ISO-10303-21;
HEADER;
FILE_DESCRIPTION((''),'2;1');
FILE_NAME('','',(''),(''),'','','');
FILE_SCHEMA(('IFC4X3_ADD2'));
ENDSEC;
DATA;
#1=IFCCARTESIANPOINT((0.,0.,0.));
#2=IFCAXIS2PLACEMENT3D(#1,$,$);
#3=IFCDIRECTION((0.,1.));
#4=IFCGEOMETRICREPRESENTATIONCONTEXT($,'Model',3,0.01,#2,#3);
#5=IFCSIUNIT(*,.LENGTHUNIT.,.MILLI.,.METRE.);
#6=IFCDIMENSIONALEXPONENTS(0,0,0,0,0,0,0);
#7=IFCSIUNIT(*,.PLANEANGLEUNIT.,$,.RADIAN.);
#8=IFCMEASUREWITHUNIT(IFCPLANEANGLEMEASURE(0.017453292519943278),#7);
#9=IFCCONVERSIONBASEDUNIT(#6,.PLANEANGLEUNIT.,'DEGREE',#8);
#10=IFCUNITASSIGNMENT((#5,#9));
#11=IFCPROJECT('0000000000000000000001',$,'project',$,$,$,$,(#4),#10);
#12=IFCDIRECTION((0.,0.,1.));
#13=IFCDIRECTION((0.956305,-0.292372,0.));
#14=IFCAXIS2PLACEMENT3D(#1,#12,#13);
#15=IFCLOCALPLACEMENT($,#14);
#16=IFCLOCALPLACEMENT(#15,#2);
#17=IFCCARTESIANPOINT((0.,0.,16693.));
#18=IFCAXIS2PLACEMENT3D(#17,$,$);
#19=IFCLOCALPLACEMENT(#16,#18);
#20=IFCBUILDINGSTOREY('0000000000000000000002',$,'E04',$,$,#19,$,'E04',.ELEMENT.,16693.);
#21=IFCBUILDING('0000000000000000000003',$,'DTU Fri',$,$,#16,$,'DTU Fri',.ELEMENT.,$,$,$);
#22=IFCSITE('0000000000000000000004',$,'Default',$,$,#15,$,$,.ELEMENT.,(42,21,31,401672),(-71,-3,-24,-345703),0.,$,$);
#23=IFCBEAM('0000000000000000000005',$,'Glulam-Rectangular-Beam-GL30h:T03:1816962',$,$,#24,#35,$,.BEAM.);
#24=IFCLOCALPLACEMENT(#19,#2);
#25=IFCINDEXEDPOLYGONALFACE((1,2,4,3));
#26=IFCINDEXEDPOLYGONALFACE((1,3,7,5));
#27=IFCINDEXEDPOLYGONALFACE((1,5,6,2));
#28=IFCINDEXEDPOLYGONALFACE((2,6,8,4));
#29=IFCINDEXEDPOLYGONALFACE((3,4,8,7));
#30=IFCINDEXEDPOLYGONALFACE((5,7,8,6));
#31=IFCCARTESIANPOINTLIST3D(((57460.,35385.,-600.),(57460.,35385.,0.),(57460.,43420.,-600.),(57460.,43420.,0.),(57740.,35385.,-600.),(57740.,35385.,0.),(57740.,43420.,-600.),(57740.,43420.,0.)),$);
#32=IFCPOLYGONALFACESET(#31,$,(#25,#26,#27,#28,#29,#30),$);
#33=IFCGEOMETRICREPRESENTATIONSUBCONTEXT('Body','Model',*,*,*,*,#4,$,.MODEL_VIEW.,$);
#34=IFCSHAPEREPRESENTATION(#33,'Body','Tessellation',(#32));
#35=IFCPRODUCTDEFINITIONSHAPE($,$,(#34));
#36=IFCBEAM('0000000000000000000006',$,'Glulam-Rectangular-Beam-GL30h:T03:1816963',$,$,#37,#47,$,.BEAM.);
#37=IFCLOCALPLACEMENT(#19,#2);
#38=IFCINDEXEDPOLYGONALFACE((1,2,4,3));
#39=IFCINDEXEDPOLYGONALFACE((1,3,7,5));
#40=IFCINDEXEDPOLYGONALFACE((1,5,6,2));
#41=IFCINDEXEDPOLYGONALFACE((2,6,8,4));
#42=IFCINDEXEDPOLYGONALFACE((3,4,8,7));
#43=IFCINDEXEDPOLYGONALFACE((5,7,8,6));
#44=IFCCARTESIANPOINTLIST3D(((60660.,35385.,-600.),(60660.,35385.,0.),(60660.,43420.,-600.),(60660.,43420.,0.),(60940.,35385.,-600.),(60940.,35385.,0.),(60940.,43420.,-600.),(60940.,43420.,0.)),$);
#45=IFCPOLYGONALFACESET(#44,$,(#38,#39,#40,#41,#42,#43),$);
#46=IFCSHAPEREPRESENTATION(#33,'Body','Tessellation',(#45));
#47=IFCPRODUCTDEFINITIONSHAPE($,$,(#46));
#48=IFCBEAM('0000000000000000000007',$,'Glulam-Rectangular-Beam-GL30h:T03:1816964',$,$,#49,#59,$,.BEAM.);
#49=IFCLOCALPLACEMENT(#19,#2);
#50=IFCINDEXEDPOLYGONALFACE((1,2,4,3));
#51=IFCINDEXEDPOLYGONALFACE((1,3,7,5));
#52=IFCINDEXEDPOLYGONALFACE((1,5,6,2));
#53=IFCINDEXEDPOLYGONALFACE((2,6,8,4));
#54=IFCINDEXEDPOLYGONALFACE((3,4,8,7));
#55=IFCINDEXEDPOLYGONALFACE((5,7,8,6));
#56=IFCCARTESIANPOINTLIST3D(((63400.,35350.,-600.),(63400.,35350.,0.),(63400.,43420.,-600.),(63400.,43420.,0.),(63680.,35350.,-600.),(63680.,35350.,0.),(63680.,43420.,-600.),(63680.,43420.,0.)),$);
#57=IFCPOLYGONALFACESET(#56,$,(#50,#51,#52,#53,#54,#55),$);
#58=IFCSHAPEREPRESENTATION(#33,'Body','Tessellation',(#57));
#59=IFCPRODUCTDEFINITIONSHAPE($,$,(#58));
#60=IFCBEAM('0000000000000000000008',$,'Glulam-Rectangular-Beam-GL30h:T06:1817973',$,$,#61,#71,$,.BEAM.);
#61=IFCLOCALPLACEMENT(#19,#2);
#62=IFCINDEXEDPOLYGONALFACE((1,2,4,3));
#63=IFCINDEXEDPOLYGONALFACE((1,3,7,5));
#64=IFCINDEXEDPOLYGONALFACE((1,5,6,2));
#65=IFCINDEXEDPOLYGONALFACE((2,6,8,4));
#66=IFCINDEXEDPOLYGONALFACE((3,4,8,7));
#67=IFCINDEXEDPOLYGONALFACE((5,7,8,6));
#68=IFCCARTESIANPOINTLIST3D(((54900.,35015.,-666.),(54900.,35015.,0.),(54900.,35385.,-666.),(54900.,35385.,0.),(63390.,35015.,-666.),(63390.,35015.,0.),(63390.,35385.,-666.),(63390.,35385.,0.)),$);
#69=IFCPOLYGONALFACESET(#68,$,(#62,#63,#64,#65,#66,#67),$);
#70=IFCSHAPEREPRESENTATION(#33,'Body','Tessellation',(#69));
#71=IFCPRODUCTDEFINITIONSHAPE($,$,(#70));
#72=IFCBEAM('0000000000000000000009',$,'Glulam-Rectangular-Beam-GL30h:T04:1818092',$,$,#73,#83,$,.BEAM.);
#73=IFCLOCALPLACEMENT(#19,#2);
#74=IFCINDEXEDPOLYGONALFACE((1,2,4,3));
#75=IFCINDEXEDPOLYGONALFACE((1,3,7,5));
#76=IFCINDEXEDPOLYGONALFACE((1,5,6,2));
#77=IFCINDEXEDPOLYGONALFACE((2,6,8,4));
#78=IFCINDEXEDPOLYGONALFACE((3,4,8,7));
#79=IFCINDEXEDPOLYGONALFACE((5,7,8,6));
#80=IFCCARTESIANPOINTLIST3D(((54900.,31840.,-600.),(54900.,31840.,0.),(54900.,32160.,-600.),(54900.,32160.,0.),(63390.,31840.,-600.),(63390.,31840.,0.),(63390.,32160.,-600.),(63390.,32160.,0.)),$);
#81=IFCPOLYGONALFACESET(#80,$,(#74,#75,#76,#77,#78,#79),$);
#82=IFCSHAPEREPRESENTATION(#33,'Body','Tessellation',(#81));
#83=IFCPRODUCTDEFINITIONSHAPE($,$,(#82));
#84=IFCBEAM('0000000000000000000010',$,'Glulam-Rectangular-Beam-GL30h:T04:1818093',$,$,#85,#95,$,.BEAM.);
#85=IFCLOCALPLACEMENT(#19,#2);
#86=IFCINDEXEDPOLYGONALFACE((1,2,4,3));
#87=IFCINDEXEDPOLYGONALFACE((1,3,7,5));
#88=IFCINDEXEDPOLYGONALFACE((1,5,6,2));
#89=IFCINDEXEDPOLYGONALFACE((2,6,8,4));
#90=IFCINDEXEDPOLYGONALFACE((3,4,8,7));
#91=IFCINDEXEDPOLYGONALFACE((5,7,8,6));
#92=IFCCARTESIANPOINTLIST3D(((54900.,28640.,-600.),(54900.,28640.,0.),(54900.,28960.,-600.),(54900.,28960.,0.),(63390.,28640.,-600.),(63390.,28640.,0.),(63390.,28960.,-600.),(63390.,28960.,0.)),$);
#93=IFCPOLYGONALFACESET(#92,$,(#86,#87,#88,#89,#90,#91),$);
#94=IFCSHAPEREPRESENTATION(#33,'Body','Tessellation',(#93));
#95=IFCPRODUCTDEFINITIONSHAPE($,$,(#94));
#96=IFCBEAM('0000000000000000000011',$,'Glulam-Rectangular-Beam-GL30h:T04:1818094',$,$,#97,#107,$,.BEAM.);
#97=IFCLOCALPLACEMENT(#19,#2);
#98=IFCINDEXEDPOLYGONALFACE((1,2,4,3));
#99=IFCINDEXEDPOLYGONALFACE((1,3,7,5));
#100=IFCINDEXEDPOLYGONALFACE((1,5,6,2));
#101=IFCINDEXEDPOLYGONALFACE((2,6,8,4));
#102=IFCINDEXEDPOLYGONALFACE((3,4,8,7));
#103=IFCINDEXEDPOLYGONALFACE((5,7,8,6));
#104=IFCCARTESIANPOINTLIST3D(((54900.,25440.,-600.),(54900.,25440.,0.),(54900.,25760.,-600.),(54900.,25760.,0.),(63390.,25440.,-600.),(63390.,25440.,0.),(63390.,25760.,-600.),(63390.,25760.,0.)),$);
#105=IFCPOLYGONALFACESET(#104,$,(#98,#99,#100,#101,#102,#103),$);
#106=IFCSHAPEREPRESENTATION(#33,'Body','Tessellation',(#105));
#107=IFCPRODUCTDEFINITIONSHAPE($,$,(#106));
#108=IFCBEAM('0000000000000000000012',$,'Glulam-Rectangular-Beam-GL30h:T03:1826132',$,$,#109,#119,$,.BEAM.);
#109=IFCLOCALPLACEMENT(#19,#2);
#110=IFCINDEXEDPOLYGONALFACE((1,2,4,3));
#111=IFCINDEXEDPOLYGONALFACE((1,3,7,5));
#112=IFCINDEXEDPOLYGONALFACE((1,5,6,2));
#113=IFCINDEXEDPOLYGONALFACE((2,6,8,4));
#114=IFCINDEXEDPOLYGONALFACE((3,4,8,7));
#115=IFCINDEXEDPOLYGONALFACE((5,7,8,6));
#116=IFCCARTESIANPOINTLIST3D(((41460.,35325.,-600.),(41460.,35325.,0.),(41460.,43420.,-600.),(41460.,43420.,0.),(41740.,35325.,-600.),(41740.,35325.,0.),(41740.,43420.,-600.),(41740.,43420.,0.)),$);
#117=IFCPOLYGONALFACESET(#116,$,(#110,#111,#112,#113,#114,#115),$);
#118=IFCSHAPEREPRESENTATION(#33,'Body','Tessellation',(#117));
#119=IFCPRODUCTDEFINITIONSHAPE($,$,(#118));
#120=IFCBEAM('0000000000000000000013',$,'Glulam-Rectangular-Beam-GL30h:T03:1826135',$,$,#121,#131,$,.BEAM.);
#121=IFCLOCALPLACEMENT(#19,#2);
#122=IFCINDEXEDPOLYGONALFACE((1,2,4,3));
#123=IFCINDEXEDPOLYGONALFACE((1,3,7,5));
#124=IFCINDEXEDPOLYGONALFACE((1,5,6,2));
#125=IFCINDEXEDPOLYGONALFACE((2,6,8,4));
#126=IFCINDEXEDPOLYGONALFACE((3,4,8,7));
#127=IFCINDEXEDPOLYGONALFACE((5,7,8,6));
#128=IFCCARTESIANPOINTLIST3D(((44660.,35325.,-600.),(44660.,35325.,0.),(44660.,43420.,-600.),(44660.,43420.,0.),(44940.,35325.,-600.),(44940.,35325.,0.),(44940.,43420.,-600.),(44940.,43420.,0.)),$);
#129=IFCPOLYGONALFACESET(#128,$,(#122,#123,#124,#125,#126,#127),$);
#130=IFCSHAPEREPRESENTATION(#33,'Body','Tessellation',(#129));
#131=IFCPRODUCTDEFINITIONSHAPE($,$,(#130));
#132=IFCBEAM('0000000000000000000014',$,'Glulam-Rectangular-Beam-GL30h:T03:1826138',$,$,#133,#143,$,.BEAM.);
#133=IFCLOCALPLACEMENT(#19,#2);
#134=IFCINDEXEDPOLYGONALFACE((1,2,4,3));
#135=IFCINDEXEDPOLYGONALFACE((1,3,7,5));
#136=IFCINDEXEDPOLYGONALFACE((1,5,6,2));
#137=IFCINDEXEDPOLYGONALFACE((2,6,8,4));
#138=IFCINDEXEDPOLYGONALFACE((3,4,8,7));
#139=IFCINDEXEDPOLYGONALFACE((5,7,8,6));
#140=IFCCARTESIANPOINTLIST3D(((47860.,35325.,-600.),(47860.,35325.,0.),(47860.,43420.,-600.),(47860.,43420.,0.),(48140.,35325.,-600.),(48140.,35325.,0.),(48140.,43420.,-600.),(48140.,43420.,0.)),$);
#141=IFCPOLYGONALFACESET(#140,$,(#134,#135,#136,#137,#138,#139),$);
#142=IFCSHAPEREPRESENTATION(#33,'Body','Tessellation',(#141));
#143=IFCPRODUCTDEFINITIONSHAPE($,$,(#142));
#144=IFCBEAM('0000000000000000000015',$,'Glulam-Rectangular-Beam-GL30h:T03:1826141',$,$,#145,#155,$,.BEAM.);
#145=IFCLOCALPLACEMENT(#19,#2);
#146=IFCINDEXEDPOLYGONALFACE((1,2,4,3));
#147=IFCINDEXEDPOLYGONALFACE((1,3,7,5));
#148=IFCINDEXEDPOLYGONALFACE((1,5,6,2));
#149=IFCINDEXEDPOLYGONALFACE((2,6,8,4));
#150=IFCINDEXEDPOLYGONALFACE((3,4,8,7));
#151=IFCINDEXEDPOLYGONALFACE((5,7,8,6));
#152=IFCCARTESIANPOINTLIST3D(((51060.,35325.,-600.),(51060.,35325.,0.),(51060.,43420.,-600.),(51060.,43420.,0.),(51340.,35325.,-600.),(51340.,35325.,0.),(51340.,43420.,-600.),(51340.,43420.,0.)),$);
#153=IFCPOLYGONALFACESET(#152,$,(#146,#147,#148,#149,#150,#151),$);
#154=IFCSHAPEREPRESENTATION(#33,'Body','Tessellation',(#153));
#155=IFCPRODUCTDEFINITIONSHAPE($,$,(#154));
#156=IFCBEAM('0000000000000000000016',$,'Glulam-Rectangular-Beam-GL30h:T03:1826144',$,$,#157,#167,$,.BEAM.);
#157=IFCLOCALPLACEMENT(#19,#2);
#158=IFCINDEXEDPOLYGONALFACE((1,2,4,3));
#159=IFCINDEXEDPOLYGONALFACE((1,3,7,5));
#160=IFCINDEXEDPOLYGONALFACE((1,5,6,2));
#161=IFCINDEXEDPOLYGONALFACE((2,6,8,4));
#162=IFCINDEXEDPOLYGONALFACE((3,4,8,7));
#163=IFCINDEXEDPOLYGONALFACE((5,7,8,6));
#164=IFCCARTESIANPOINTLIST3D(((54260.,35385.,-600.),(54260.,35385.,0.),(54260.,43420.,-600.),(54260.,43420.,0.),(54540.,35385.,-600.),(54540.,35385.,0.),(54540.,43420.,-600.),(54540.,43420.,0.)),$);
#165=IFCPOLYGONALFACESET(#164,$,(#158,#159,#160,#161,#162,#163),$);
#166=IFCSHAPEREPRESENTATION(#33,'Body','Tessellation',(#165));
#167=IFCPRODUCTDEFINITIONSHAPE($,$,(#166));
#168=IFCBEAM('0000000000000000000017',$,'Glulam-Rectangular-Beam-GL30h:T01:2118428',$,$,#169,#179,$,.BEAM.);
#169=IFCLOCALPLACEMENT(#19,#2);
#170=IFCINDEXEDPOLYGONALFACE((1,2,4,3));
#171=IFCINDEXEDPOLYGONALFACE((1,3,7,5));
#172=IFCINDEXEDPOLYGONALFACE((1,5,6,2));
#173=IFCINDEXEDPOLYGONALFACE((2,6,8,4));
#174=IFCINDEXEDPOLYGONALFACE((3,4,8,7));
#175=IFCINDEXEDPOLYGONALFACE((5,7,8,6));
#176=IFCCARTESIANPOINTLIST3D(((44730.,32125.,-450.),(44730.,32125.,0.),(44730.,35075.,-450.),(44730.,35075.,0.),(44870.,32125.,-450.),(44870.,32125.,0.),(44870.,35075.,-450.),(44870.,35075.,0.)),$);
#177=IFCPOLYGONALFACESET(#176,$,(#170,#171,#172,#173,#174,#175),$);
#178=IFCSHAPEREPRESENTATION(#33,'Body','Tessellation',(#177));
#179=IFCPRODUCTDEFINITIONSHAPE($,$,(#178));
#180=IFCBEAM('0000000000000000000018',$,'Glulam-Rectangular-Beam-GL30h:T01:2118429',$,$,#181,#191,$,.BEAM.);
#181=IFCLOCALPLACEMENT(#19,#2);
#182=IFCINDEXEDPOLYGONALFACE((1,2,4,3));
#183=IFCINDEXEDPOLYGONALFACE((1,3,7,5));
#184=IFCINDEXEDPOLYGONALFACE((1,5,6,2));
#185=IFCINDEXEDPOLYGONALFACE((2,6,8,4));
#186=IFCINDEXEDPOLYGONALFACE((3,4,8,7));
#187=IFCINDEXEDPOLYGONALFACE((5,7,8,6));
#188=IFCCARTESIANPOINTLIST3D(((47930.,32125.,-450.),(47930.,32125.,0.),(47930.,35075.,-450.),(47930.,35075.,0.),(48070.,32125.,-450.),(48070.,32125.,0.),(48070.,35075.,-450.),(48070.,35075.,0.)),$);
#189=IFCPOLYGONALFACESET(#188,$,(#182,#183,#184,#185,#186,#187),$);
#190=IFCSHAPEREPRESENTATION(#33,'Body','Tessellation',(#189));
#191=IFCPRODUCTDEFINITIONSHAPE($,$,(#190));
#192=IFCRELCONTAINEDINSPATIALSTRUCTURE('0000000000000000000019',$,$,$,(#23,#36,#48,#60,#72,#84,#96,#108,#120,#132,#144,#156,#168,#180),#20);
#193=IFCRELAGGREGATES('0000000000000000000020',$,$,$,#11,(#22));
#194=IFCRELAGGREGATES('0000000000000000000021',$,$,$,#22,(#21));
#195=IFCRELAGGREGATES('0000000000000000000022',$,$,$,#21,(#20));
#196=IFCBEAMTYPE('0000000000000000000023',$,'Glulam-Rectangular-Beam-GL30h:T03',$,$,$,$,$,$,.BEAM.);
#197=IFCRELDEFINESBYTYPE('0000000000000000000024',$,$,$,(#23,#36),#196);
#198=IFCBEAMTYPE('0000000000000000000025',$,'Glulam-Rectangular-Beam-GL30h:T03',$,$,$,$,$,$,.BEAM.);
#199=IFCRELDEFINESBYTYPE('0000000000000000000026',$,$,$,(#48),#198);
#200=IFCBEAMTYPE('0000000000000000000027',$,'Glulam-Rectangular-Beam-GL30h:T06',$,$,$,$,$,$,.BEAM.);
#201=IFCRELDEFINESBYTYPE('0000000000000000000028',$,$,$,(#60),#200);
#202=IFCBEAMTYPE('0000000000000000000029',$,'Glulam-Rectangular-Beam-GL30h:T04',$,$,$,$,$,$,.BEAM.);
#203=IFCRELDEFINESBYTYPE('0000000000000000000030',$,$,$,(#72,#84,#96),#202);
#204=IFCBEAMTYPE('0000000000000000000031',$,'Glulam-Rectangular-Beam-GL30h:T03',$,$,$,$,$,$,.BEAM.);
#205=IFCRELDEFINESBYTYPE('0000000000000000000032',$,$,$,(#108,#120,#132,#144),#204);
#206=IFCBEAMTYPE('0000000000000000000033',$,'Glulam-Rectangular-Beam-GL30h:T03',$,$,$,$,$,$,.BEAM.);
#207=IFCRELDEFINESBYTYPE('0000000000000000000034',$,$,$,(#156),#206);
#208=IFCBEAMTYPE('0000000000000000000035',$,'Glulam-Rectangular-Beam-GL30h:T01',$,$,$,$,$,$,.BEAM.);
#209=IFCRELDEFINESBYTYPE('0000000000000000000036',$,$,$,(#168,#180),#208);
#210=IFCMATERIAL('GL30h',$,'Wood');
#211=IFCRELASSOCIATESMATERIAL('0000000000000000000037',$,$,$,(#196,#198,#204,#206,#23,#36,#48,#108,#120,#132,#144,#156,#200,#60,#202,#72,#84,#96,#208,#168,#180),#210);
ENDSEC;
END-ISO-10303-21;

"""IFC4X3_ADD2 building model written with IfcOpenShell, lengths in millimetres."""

from ifc_helpers import new_model, entity, si_unit, converted_unit, direction, frame, origin, origin_2d_with_axis, place, context, subcontext, project, spatial, rectangle, extrude, source, transform, mapped, material, material_profile, profile_set, profile_usage, type_object, type_shapes, element, save


model = new_model("IFC4X3_ADD2")

# Units and contexts
model_context = context("Model", 3, precision=0.01, world=origin(), true_north=direction((0.0, 1.0)))
body_context = subcontext(model_context, "Body", "Model", "MODEL_VIEW")
ifc_project = project(units=[si_unit("LENGTHUNIT", "METRE", prefix="MILLI"), converted_unit("PLANEANGLEUNIT", "DEGREE", entity("IfcPlaneAngleMeasure", 0.017453292519943278), si_unit("PLANEANGLEUNIT", "RADIAN"), dimensions=[0, 0, 0, 0, 0, 0, 0])], contexts=[model_context])

# Site, building, storey
site_placement = place(None, frame((0.0, 0.0, 0.0), z_axis=(0.0, 0.0, 1.0), x_axis=(0.956305, -0.292372, 0.0)))
site = spatial("IfcSite", under=ifc_project, at=site_placement, Name="Default", CompositionType="ELEMENT", RefLatitude=(42, 21, 31, 401672), RefLongitude=(-71, -3, -24, -345703), RefElevation=0.0)
building_placement = place(site_placement, origin())
building = spatial("IfcBuilding", under=site, at=building_placement, Name="DTU Fri", LongName="DTU Fri", CompositionType="ELEMENT")
storey_placement = place(building_placement, frame((0.0, 0.0, 16693.0)))
storey = spatial("IfcBuildingStorey", under=building, at=storey_placement, Name="E04", LongName="E04", CompositionType="ELEMENT", Elevation=16693.0)

# Beams
ifc_material = material(Name="GL30h", Category="Wood")
ifc_material_profile_1 = material_profile(ifc_material, rectangle(XDim=600.0, YDim=280.0, at=origin_2d_with_axis()), Name="T03")
ifc_profile_set_1 = profile_set([ifc_material_profile_1], Name="T03")
ifc_profile_usage_1 = profile_usage(ifc_profile_set_1, cardinal=8)
beam_type_1 = type_object("IfcBeamType", Name="Glulam-Rectangular-Beam-GL30h:T03", PredefinedType="BEAM", material=ifc_profile_set_1)
shared_shape_1 = source(origin(), body_context, "Body", "SweptSolid", [
    extrude(rectangle(XDim=600.0, YDim=280.0, at=origin_2d_with_axis()), frame((-4060.0, 0.0, 0.0), z_axis=(1.0, 0.0, 0.0), x_axis=(0.0, 0.0, -1.0)), (0.0, 0.0, 1.0), 8035.0),
])
type_shapes(beam_type_1, [shared_shape_1])
for number, where, z_axis, x_axis, name in (
    (1, (57600.0, 39360.0, -300.0), (0.0, 0.0, 1.0), (0.0, -1.0, 0.0), "Glulam-Rectangular-Beam-GL30h:T03:1816962"),
    (2, (60800.0, 39360.0, -300.0), (0.0, 0.0, 1.0), (0.0, -1.0, 0.0), "Glulam-Rectangular-Beam-GL30h:T03:1816963"),
):
    element("IfcBeam", number, at=place(storey_placement, frame(where, z_axis=z_axis, x_axis=x_axis)), inside=storey, type_object=beam_type_1, material=ifc_profile_usage_1, Name=name, PredefinedType="BEAM", context=body_context, shape_type="MappedRepresentation", body=[
        mapped(shared_shape_1, transform((0.0, 0.0, 0.0), scale=1.0)),
    ])
beam_type_2 = type_object("IfcBeamType", Name="Glulam-Rectangular-Beam-GL30h:T03", PredefinedType="BEAM", material=ifc_profile_set_1)
shared_shape_2 = source(origin(), body_context, "Body", "SweptSolid", [
    extrude(rectangle(XDim=600.0, YDim=280.0, at=origin_2d_with_axis()), frame((-4060.0, 0.0, 0.0), z_axis=(1.0, 0.0, 0.0), x_axis=(0.0, 0.0, -1.0)), (0.0, 0.0, 1.0), 8070.0),
])
type_shapes(beam_type_2, [shared_shape_2])
beam_1_placement = place(storey_placement, frame((63540.0, 39360.0, -300.0), z_axis=(0.0, 0.0, 1.0), x_axis=(0.0, -1.0, 0.0)))
element("IfcBeam", 3, at=beam_1_placement, inside=storey, type_object=beam_type_2, material=ifc_profile_usage_1, Name="Glulam-Rectangular-Beam-GL30h:T03:1816964", PredefinedType="BEAM", context=body_context, shape_type="MappedRepresentation", body=[
    mapped(shared_shape_2, transform((0.0, 0.0, 0.0), scale=1.0)),
])
ifc_material_profile_2 = material_profile(ifc_material, rectangle(XDim=666.0, YDim=370.0, at=origin_2d_with_axis()), Name="T06")
ifc_profile_set_2 = profile_set([ifc_material_profile_2], Name="T06")
ifc_profile_usage_2 = profile_usage(ifc_profile_set_2, cardinal=8)
beam_type_3 = type_object("IfcBeamType", Name="Glulam-Rectangular-Beam-GL30h:T06", PredefinedType="BEAM", material=ifc_profile_set_2)
shared_shape_3 = source(origin(), body_context, "Body", "SweptSolid", [
    extrude(rectangle(XDim=666.0, YDim=370.0, at=origin_2d_with_axis()), frame((-4187.5, 0.0, 0.0), z_axis=(1.0, 0.0, 0.0), x_axis=(0.0, 0.0, -1.0)), (0.0, 0.0, 1.0), 8490.0),
])
type_shapes(beam_type_3, [shared_shape_3])
beam_2_placement = place(storey_placement, frame((59087.5, 35200.0, -333.0)))
element("IfcBeam", 4, at=beam_2_placement, inside=storey, type_object=beam_type_3, material=ifc_profile_usage_2, Name="Glulam-Rectangular-Beam-GL30h:T06:1817973", PredefinedType="BEAM", context=body_context, shape_type="MappedRepresentation", body=[
    mapped(shared_shape_3, transform((0.0, 0.0, 0.0), scale=1.0)),
])
ifc_material_profile_3 = material_profile(ifc_material, rectangle(XDim=600.0, YDim=320.0, at=origin_2d_with_axis()), Name="T04")
ifc_profile_set_3 = profile_set([ifc_material_profile_3], Name="T04")
ifc_profile_usage_3 = profile_usage(ifc_profile_set_3, cardinal=8)
beam_type_4 = type_object("IfcBeamType", Name="Glulam-Rectangular-Beam-GL30h:T04", PredefinedType="BEAM", material=ifc_profile_set_3)
shared_shape_4 = source(origin(), body_context, "Body", "SweptSolid", [
    extrude(rectangle(XDim=600.0, YDim=320.0, at=origin_2d_with_axis()), frame((-4200.0, 0.0, 0.0), z_axis=(1.0, 0.0, 0.0), x_axis=(0.0, 0.0, -1.0)), (0.0, 0.0, 1.0), 8490.0),
])
type_shapes(beam_type_4, [shared_shape_4])
for number, where, name in (
    (5, (59100.0, 32000.0, -300.0), "Glulam-Rectangular-Beam-GL30h:T04:1818092"),
    (6, (59100.0, 28800.0, -300.0), "Glulam-Rectangular-Beam-GL30h:T04:1818093"),
    (7, (59100.0, 25600.0, -300.0), "Glulam-Rectangular-Beam-GL30h:T04:1818094"),
):
    element("IfcBeam", number, at=place(storey_placement, frame(where)), inside=storey, type_object=beam_type_4, material=ifc_profile_usage_3, Name=name, PredefinedType="BEAM", context=body_context, shape_type="MappedRepresentation", body=[
        mapped(shared_shape_4, transform((0.0, 0.0, 0.0), scale=1.0)),
    ])
beam_type_5 = type_object("IfcBeamType", Name="Glulam-Rectangular-Beam-GL30h:T03", PredefinedType="BEAM", material=ifc_profile_set_1)
shared_shape_5 = source(origin(), body_context, "Body", "SweptSolid", [
    extrude(rectangle(XDim=600.0, YDim=280.0, at=origin_2d_with_axis()), frame((-4060.0, 0.0, 0.0), z_axis=(1.0, 0.0, 0.0), x_axis=(0.0, 0.0, -1.0)), (0.0, 0.0, 1.0), 8095.0),
])
type_shapes(beam_type_5, [shared_shape_5])
for number, where, z_axis, x_axis, name in (
    (8, (41600.0, 39360.0, -300.0), (0.0, 0.0, 1.0), (0.0, -1.0, 0.0), "Glulam-Rectangular-Beam-GL30h:T03:1826132"),
    (9, (44800.0, 39360.0, -300.0), (0.0, 0.0, 1.0), (0.0, -1.0, 0.0), "Glulam-Rectangular-Beam-GL30h:T03:1826135"),
    (10, (48000.0, 39360.0, -300.0), (0.0, 0.0, 1.0), (0.0, -1.0, 0.0), "Glulam-Rectangular-Beam-GL30h:T03:1826138"),
    (11, (51200.0, 39360.0, -300.0), (0.0, 0.0, 1.0), (0.0, -1.0, 0.0), "Glulam-Rectangular-Beam-GL30h:T03:1826141"),
):
    element("IfcBeam", number, at=place(storey_placement, frame(where, z_axis=z_axis, x_axis=x_axis)), inside=storey, type_object=beam_type_5, material=ifc_profile_usage_1, Name=name, PredefinedType="BEAM", context=body_context, shape_type="MappedRepresentation", body=[
        mapped(shared_shape_5, transform((0.0, 0.0, 0.0), scale=1.0)),
    ])
beam_type_6 = type_object("IfcBeamType", Name="Glulam-Rectangular-Beam-GL30h:T03", PredefinedType="BEAM", material=ifc_profile_set_1)
shared_shape_6 = source(origin(), body_context, "Body", "SweptSolid", [
    extrude(rectangle(XDim=600.0, YDim=280.0, at=origin_2d_with_axis()), frame((-4060.0, 0.0, 0.0), z_axis=(1.0, 0.0, 0.0), x_axis=(0.0, 0.0, -1.0)), (0.0, 0.0, 1.0), 8035.0),
])
type_shapes(beam_type_6, [shared_shape_6])
beam_3_placement = place(storey_placement, frame((54400.0, 39360.0, -300.0), z_axis=(0.0, 0.0, 1.0), x_axis=(0.0, -1.0, 0.0)))
element("IfcBeam", 12, at=beam_3_placement, inside=storey, type_object=beam_type_6, material=ifc_profile_usage_1, Name="Glulam-Rectangular-Beam-GL30h:T03:1826144", PredefinedType="BEAM", context=body_context, shape_type="MappedRepresentation", body=[
    mapped(shared_shape_6, transform((0.0, 0.0, 0.0), scale=1.0)),
])
ifc_material_profile_4 = material_profile(ifc_material, rectangle(XDim=450.0, YDim=140.0, at=origin_2d_with_axis()), Name="T01")
ifc_profile_set_4 = profile_set([ifc_material_profile_4], Name="T01")
ifc_profile_usage_4 = profile_usage(ifc_profile_set_4, cardinal=8)
beam_type_7 = type_object("IfcBeamType", Name="Glulam-Rectangular-Beam-GL30h:T01", PredefinedType="BEAM", material=ifc_profile_set_4)
shared_shape_7 = source(origin(), body_context, "Body", "SweptSolid", [
    extrude(rectangle(XDim=450.0, YDim=140.0, at=origin_2d_with_axis()), frame((-1475.0, 0.0, 0.0), z_axis=(1.0, 0.0, 0.0), x_axis=(0.0, 0.0, -1.0)), (0.0, 0.0, 1.0), 2950.0),
])
type_shapes(beam_type_7, [shared_shape_7])
for number, where, z_axis, x_axis, name in (
    (13, (44800.0, 33600.0, -225.0), (0.0, 0.0, 1.0), (0.0, 1.0, 0.0), "Glulam-Rectangular-Beam-GL30h:T01:2118428"),
    (14, (48000.0, 33600.0, -225.0), (0.0, 0.0, 1.0), (0.0, 1.0, 0.0), "Glulam-Rectangular-Beam-GL30h:T01:2118429"),
):
    element("IfcBeam", number, at=place(storey_placement, frame(where, z_axis=z_axis, x_axis=x_axis)), inside=storey, type_object=beam_type_7, material=ifc_profile_usage_4, Name=name, PredefinedType="BEAM", context=body_context, shape_type="MappedRepresentation", body=[
        mapped(shared_shape_7, transform((0.0, 0.0, 0.0), scale=1.0)),
    ])

save(model, "model.ifc")
